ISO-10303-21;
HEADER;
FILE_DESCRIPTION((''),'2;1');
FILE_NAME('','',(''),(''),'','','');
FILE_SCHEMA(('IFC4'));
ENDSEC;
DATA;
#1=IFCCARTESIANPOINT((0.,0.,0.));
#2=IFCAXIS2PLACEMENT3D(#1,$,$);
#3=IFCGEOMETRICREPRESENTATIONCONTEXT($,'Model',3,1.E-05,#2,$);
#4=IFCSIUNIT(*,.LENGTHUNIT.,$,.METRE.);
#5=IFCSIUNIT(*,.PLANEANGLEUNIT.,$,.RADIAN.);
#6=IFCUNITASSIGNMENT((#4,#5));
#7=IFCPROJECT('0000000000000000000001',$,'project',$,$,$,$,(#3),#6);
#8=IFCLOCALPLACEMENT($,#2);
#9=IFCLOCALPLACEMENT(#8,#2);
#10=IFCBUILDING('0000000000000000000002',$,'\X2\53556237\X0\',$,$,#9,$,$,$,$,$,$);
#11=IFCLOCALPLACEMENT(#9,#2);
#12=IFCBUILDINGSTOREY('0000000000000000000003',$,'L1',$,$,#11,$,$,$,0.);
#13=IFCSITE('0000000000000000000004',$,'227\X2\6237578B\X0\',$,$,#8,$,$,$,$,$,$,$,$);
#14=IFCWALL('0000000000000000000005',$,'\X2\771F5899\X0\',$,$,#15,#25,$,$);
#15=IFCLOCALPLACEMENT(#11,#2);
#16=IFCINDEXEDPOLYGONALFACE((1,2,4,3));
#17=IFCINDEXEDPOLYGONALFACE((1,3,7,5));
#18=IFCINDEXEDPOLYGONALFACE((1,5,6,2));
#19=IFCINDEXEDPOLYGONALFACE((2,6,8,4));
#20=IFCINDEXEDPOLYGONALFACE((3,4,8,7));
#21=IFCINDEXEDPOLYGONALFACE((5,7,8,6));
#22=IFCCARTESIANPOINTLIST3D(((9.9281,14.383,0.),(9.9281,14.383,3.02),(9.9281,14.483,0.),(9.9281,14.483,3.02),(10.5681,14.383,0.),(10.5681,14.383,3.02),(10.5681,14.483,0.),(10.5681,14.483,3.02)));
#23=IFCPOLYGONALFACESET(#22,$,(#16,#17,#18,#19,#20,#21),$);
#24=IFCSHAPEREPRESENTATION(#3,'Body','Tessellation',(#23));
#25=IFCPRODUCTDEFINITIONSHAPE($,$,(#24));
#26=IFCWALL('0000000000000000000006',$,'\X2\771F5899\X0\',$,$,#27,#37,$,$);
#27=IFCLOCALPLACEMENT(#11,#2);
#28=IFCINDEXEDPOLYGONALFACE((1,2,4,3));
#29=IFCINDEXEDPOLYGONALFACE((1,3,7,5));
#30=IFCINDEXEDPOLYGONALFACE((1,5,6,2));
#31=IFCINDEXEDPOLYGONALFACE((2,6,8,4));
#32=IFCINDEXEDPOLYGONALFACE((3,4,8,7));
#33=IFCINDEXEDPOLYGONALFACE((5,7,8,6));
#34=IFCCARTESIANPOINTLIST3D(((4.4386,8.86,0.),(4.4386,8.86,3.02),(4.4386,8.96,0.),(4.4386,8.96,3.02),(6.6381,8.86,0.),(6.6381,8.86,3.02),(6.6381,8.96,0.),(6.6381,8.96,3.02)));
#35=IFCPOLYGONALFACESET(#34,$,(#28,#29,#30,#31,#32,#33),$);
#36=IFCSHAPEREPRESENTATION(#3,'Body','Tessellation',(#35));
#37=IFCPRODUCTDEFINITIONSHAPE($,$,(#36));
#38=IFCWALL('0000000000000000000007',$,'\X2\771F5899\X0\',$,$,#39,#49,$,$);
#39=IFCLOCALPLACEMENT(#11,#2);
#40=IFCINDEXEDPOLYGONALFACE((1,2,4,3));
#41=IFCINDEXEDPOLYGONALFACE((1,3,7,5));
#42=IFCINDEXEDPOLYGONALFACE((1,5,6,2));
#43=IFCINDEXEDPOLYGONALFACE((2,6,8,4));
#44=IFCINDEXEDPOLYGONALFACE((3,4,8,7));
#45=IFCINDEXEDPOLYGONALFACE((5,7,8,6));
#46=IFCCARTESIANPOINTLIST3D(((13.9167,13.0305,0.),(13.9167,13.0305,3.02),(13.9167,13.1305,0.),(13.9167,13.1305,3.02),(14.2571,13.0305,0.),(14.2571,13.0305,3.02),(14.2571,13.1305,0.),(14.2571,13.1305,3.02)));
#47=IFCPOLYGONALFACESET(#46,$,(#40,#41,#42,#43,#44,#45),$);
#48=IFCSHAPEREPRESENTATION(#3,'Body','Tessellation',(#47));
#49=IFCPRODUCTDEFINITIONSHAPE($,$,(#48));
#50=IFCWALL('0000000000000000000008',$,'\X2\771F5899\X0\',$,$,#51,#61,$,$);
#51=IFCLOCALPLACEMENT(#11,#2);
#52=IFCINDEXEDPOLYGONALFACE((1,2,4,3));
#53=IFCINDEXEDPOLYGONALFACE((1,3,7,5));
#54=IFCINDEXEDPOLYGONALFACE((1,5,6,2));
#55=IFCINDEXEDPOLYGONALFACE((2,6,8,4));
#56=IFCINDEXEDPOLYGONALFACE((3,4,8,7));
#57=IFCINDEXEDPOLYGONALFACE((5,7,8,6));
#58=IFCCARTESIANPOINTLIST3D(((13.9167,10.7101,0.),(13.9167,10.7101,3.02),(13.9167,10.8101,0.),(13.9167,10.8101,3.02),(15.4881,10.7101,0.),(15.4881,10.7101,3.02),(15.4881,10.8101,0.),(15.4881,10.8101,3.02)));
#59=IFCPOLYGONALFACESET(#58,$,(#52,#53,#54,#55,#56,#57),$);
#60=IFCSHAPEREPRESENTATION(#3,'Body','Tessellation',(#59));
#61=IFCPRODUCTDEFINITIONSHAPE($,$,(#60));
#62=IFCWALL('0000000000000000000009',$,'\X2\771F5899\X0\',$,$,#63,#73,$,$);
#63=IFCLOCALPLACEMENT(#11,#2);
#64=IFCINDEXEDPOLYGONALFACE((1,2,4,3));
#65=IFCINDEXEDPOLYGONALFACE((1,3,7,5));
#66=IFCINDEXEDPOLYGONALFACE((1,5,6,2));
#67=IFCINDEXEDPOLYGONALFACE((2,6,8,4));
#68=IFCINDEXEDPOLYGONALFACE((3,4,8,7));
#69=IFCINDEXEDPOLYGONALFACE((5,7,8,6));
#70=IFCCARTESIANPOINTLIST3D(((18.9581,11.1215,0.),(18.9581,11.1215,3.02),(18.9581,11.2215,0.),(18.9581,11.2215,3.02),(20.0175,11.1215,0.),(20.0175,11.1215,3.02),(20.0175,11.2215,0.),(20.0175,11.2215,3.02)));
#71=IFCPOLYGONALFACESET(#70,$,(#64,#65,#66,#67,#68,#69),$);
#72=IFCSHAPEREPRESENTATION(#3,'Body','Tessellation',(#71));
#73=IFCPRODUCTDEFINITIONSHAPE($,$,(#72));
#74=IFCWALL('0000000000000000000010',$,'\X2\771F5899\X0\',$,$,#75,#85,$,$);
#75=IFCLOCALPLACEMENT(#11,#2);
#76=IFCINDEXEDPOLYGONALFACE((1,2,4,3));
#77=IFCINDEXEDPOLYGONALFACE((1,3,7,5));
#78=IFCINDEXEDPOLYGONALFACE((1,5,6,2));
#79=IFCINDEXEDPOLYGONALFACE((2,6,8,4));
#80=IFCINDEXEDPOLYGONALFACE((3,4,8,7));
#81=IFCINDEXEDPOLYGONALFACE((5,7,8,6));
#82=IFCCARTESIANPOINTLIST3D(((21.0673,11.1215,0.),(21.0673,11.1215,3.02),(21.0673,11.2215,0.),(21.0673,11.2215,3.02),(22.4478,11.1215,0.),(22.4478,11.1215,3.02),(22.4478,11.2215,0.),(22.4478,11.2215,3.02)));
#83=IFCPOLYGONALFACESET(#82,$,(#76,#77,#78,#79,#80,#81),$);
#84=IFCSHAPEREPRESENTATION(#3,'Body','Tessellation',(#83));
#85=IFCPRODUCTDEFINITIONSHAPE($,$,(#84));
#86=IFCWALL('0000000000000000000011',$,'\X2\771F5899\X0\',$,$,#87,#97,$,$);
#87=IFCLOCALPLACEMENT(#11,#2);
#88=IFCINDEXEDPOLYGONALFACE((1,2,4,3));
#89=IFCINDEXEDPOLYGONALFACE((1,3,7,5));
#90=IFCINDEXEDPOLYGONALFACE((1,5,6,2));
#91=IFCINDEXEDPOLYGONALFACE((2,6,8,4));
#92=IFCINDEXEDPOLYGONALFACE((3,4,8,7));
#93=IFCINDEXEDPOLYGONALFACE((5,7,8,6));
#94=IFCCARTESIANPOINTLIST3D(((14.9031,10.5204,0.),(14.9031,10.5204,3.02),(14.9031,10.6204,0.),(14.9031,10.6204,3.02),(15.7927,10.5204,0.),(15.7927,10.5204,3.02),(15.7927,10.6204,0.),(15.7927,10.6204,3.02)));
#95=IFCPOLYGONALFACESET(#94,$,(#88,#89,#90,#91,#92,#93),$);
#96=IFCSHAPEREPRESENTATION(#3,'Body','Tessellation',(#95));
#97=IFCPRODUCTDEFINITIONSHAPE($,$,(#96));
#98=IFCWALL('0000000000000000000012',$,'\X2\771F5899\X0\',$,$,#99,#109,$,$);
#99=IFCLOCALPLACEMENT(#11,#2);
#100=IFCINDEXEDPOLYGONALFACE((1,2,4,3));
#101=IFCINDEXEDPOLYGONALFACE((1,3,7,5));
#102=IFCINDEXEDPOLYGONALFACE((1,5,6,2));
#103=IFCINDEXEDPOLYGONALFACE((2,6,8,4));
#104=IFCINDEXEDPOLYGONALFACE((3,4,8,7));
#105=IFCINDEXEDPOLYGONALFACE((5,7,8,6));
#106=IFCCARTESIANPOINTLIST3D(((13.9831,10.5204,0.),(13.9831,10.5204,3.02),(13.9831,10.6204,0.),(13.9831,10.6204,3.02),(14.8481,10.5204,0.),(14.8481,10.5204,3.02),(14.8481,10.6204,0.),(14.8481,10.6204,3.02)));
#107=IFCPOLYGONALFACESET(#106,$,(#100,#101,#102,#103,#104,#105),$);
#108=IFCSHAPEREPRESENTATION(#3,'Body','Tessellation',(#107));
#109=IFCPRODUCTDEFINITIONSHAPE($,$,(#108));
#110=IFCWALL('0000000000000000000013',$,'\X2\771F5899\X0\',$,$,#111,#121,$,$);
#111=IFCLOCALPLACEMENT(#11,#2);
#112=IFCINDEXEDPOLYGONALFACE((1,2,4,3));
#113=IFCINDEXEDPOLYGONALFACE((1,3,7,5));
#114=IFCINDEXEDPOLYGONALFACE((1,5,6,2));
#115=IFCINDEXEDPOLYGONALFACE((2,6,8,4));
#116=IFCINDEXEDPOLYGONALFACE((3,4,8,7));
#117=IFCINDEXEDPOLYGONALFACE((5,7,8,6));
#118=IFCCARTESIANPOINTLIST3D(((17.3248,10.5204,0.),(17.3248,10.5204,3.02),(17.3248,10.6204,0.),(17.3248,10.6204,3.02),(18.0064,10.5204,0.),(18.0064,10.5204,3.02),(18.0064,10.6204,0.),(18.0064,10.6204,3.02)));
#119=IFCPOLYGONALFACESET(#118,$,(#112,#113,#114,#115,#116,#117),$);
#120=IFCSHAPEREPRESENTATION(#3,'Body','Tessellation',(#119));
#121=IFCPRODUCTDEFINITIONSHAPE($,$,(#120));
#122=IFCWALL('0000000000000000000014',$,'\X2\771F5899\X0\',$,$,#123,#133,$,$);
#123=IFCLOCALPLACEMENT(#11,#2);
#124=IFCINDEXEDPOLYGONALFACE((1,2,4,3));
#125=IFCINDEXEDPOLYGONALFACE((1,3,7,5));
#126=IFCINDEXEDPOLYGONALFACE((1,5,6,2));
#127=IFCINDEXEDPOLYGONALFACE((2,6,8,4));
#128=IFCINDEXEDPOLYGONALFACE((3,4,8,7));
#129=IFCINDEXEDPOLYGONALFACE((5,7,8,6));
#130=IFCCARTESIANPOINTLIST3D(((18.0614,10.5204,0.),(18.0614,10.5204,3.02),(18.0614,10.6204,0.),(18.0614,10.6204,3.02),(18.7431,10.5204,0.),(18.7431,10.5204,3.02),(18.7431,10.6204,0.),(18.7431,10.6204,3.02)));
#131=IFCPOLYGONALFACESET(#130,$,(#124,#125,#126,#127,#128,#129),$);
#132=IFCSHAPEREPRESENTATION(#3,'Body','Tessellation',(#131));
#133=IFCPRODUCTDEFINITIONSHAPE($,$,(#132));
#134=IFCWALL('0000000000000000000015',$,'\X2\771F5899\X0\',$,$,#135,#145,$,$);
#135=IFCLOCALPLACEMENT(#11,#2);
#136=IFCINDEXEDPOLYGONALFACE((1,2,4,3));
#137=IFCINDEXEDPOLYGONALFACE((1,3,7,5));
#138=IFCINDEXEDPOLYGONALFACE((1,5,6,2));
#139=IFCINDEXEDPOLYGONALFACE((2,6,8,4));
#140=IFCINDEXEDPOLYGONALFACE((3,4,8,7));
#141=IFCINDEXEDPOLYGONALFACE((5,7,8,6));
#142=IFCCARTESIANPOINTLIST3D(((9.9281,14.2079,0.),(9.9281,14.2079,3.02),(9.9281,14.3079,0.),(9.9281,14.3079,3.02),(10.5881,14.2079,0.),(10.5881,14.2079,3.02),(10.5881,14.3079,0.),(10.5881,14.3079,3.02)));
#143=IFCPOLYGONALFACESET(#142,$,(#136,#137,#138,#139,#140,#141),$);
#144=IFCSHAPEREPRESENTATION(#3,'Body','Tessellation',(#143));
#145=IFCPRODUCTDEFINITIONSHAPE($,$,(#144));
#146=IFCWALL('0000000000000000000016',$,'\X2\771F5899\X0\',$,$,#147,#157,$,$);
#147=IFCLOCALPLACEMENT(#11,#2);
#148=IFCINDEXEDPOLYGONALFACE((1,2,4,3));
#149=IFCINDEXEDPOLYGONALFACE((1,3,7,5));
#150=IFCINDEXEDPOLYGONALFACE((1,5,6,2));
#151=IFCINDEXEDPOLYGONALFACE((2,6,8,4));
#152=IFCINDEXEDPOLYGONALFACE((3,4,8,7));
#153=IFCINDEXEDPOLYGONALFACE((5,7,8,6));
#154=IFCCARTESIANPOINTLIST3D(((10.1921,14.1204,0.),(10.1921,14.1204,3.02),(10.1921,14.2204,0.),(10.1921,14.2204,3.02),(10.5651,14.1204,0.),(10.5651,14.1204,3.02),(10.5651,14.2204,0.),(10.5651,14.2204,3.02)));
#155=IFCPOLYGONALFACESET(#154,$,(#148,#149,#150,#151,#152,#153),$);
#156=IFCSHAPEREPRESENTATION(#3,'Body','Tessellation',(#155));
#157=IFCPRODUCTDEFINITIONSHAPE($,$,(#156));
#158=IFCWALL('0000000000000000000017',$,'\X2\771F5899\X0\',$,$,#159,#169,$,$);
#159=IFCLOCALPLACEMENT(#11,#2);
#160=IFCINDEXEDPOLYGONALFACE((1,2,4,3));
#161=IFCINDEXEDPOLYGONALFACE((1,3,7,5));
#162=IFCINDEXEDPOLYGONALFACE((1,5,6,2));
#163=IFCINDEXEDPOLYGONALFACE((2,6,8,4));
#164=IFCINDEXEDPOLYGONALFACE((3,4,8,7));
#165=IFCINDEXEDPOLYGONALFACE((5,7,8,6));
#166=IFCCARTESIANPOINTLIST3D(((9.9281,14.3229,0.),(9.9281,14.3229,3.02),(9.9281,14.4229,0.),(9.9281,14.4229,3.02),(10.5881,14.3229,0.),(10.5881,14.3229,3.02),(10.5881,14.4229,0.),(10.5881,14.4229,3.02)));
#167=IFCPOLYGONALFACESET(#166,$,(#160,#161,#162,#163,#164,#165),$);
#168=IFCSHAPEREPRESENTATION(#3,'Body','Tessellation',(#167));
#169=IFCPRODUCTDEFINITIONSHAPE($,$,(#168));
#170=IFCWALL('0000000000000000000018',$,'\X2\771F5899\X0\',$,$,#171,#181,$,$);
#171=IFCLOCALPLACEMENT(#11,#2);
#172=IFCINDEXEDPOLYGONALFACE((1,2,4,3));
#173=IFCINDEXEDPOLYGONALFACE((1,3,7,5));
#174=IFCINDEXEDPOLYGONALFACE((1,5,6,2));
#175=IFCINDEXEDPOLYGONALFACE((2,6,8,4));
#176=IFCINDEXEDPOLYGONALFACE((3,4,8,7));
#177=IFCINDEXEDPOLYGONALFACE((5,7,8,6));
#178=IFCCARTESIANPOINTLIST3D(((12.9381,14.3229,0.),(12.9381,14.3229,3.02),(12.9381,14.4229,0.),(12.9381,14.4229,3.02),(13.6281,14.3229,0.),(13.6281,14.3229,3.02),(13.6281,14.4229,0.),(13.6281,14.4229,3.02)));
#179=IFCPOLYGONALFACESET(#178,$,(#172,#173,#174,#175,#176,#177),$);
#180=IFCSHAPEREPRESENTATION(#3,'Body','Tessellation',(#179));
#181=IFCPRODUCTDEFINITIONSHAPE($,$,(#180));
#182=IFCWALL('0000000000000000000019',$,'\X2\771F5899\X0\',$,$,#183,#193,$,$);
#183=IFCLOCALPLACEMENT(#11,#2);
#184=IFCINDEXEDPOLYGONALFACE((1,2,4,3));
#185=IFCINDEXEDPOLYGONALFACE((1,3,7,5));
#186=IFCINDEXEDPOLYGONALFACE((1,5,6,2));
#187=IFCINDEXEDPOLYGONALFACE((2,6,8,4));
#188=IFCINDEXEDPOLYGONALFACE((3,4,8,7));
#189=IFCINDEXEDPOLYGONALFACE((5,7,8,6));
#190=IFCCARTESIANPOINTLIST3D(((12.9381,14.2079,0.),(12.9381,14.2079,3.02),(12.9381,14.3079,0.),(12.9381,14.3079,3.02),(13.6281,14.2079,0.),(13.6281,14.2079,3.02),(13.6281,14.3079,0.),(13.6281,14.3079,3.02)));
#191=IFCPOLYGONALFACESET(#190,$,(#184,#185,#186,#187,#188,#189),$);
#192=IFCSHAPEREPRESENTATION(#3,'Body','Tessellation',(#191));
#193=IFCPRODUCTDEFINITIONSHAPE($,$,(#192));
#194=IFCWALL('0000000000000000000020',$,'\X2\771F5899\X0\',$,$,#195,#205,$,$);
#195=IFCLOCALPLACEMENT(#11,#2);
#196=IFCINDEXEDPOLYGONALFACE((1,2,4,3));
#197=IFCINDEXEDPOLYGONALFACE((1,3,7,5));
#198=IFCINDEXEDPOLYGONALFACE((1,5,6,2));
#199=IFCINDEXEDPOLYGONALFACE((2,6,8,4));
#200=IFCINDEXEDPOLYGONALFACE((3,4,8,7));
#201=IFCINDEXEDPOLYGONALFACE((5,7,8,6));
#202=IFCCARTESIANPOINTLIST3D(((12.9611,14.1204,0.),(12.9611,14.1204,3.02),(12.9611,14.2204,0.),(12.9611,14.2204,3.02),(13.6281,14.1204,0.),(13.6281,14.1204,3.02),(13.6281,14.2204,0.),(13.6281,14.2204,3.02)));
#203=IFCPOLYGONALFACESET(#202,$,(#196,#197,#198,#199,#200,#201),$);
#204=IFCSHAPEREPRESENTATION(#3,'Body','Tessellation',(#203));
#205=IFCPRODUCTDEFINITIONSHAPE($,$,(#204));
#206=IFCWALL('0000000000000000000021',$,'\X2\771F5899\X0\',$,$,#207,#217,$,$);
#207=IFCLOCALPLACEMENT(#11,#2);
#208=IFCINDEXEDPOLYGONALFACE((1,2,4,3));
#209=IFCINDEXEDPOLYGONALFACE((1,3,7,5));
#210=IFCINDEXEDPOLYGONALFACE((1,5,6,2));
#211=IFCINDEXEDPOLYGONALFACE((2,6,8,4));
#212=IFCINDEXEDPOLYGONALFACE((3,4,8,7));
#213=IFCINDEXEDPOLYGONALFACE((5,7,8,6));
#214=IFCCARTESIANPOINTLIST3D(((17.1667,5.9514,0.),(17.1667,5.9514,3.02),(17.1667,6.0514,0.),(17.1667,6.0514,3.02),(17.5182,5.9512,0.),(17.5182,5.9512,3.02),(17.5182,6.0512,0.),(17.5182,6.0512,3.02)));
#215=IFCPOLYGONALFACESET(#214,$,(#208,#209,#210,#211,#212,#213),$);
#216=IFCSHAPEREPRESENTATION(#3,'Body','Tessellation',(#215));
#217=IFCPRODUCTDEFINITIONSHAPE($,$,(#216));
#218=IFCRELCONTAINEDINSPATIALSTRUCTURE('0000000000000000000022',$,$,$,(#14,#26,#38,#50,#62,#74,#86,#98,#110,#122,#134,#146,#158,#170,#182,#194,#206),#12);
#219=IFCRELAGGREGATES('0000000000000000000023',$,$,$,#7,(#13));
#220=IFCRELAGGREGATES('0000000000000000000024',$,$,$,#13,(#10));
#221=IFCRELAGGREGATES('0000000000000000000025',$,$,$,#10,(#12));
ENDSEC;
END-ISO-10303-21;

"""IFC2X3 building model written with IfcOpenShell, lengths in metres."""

from ifc_helpers import new_model, si_unit, origin, place, context, project, spatial, polyline, outline, extrude, element, save


model = new_model("IFC2X3")

# Units and contexts
model_context = context("Model", 3, precision=1e-05, world=origin())
ifc_project = project(units=[si_unit("LENGTHUNIT", "METRE"), si_unit("PLANEANGLEUNIT", "RADIAN")], contexts=[model_context])

# Site, building, storey
site_placement = place(None, origin())
site = spatial("IfcSite", under=ifc_project, at=site_placement, Name="227户型")
building_placement = place(site_placement, origin())
building = spatial("IfcBuilding", under=site, at=building_placement, Name="单户")
storey_placement = place(building_placement, origin())
storey = spatial("IfcBuildingStorey", under=building, at=storey_placement, Name="L1", Elevation=0.0)

# Walls
wall_1_placement = place(storey_placement, origin())
element("IfcWall", 1, at=wall_1_placement, inside=storey, Name="真墙", context=model_context, shape_type="SweptSolid", body=[
    extrude(outline(polyline([(10.5681, 14.383), (9.9281, 14.383), (9.9281, 14.483), (10.5681, 14.483), (10.5681, 14.383)])), origin(), (0.0, 0.0, 1.0), 3.02),
])
wall_2_placement = place(storey_placement, origin())
element("IfcWall", 2, at=wall_2_placement, inside=storey, Name="真墙", context=model_context, shape_type="SweptSolid", body=[
    extrude(outline(polyline([(6.6381, 8.86), (4.4386, 8.86), (4.4386, 8.96), (6.6381, 8.96), (6.6381, 8.86)])), origin(), (0.0, 0.0, 1.0), 3.02),
])
wall_3_placement = place(storey_placement, origin())
element("IfcWall", 3, at=wall_3_placement, inside=storey, Name="真墙", context=model_context, shape_type="SweptSolid", body=[
    extrude(outline(polyline([(14.2571, 13.0305), (13.9167, 13.0305), (13.9167, 13.1305), (14.2571, 13.1305), (14.2571, 13.0305)])), origin(), (0.0, 0.0, 1.0), 3.02),
])
wall_4_placement = place(storey_placement, origin())
element("IfcWall", 4, at=wall_4_placement, inside=storey, Name="真墙", context=model_context, shape_type="SweptSolid", body=[
    extrude(outline(polyline([(13.9167, 10.8101), (15.4881, 10.8101), (15.4881, 10.7101), (13.9167, 10.7101), (13.9167, 10.8101)])), origin(), (0.0, 0.0, 1.0), 3.02),
])
wall_5_placement = place(storey_placement, origin())
element("IfcWall", 5, at=wall_5_placement, inside=storey, Name="真墙", context=model_context, shape_type="SweptSolid", body=[
    extrude(outline(polyline([(20.0175, 11.1215), (18.9581, 11.1215), (18.9581, 11.2215), (20.0175, 11.2215), (20.0175, 11.1215)])), origin(), (0.0, 0.0, 1.0), 3.02),
])
wall_6_placement = place(storey_placement, origin())
element("IfcWall", 6, at=wall_6_placement, inside=storey, Name="真墙", context=model_context, shape_type="SweptSolid", body=[
    extrude(outline(polyline([(21.0673, 11.2215), (22.4478, 11.2215), (22.4478, 11.1215), (21.0673, 11.1215), (21.0673, 11.2215)])), origin(), (0.0, 0.0, 1.0), 3.02),
])

# Walls
wall_7_placement = place(storey_placement, origin())
element("IfcWall", 7, at=wall_7_placement, inside=storey, Name="真墙", context=model_context, shape_type="SweptSolid", body=[
    extrude(outline(polyline([(14.9031, 10.6204), (15.7927, 10.6204), (15.7927, 10.5204), (14.9031, 10.5204), (14.9031, 10.6204)])), origin(), (0.0, 0.0, 1.0), 3.02),
])
wall_8_placement = place(storey_placement, origin())
element("IfcWall", 8, at=wall_8_placement, inside=storey, Name="真墙", context=model_context, shape_type="SweptSolid", body=[
    extrude(outline(polyline([(13.9831, 10.6204), (14.8481, 10.6204), (14.8481, 10.5204), (13.9831, 10.5204), (13.9831, 10.6204)])), origin(), (0.0, 0.0, 1.0), 3.02),
])
wall_9_placement = place(storey_placement, origin())
element("IfcWall", 9, at=wall_9_placement, inside=storey, Name="真墙", context=model_context, shape_type="SweptSolid", body=[
    extrude(outline(polyline([(18.0064, 10.5204), (17.3248, 10.5204), (17.3248, 10.6204), (18.0064, 10.6204), (18.0064, 10.5204)])), origin(), (0.0, 0.0, 1.0), 3.02),
])
wall_10_placement = place(storey_placement, origin())
element("IfcWall", 10, at=wall_10_placement, inside=storey, Name="真墙", context=model_context, shape_type="SweptSolid", body=[
    extrude(outline(polyline([(18.7431, 10.5204), (18.0614, 10.5204), (18.0614, 10.6204), (18.7431, 10.6204), (18.7431, 10.5204)])), origin(), (0.0, 0.0, 1.0), 3.02),
])
wall_11_placement = place(storey_placement, origin())
element("IfcWall", 11, at=wall_11_placement, inside=storey, Name="真墙", context=model_context, shape_type="SweptSolid", body=[
    extrude(outline(polyline([(10.5881, 14.2079), (9.9281, 14.2079), (9.9281, 14.3079), (10.5881, 14.3079), (10.5881, 14.2079)])), origin(), (0.0, 0.0, 1.0), 3.02),
])
wall_12_placement = place(storey_placement, origin())
element("IfcWall", 12, at=wall_12_placement, inside=storey, Name="真墙", context=model_context, shape_type="SweptSolid", body=[
    extrude(outline(polyline([(10.5651, 14.1204), (10.1921, 14.1204), (10.1921, 14.2204), (10.5651, 14.2204), (10.5651, 14.1204)])), origin(), (0.0, 0.0, 1.0), 3.02),
])
wall_13_placement = place(storey_placement, origin())
element("IfcWall", 13, at=wall_13_placement, inside=storey, Name="真墙", context=model_context, shape_type="SweptSolid", body=[
    extrude(outline(polyline([(10.5881, 14.3229), (9.9281, 14.3229), (9.9281, 14.4229), (10.5881, 14.4229), (10.5881, 14.3229)])), origin(), (0.0, 0.0, 1.0), 3.02),
])

# Walls
wall_14_placement = place(storey_placement, origin())
element("IfcWall", 14, at=wall_14_placement, inside=storey, Name="真墙", context=model_context, shape_type="SweptSolid", body=[
    extrude(outline(polyline([(12.9381, 14.4229), (13.6281, 14.4229), (13.6281, 14.3229), (12.9381, 14.3229), (12.9381, 14.4229)])), origin(), (0.0, 0.0, 1.0), 3.02),
])
wall_15_placement = place(storey_placement, origin())
element("IfcWall", 15, at=wall_15_placement, inside=storey, Name="真墙", context=model_context, shape_type="SweptSolid", body=[
    extrude(outline(polyline([(12.9381, 14.3079), (13.6281, 14.3079), (13.6281, 14.2079), (12.9381, 14.2079), (12.9381, 14.3079)])), origin(), (0.0, 0.0, 1.0), 3.02),
])
wall_16_placement = place(storey_placement, origin())
element("IfcWall", 16, at=wall_16_placement, inside=storey, Name="真墙", context=model_context, shape_type="SweptSolid", body=[
    extrude(outline(polyline([(12.9611, 14.2204), (13.6281, 14.2204), (13.6281, 14.1204), (12.9611, 14.1204), (12.9611, 14.2204)])), origin(), (0.0, 0.0, 1.0), 3.02),
])

# Wall
wall_17_placement = place(storey_placement, origin())
element("IfcWall", 17, at=wall_17_placement, inside=storey, Name="真墙", context=model_context, shape_type="SweptSolid", body=[
    extrude(outline(polyline([(17.5182, 5.9512), (17.1667, 5.9514), (17.1667, 6.0514), (17.5182, 6.0512), (17.5182, 5.9512)])), origin(), (0.0, 0.0, 1.0), 3.02),
])

save(model, "model.ifc")
